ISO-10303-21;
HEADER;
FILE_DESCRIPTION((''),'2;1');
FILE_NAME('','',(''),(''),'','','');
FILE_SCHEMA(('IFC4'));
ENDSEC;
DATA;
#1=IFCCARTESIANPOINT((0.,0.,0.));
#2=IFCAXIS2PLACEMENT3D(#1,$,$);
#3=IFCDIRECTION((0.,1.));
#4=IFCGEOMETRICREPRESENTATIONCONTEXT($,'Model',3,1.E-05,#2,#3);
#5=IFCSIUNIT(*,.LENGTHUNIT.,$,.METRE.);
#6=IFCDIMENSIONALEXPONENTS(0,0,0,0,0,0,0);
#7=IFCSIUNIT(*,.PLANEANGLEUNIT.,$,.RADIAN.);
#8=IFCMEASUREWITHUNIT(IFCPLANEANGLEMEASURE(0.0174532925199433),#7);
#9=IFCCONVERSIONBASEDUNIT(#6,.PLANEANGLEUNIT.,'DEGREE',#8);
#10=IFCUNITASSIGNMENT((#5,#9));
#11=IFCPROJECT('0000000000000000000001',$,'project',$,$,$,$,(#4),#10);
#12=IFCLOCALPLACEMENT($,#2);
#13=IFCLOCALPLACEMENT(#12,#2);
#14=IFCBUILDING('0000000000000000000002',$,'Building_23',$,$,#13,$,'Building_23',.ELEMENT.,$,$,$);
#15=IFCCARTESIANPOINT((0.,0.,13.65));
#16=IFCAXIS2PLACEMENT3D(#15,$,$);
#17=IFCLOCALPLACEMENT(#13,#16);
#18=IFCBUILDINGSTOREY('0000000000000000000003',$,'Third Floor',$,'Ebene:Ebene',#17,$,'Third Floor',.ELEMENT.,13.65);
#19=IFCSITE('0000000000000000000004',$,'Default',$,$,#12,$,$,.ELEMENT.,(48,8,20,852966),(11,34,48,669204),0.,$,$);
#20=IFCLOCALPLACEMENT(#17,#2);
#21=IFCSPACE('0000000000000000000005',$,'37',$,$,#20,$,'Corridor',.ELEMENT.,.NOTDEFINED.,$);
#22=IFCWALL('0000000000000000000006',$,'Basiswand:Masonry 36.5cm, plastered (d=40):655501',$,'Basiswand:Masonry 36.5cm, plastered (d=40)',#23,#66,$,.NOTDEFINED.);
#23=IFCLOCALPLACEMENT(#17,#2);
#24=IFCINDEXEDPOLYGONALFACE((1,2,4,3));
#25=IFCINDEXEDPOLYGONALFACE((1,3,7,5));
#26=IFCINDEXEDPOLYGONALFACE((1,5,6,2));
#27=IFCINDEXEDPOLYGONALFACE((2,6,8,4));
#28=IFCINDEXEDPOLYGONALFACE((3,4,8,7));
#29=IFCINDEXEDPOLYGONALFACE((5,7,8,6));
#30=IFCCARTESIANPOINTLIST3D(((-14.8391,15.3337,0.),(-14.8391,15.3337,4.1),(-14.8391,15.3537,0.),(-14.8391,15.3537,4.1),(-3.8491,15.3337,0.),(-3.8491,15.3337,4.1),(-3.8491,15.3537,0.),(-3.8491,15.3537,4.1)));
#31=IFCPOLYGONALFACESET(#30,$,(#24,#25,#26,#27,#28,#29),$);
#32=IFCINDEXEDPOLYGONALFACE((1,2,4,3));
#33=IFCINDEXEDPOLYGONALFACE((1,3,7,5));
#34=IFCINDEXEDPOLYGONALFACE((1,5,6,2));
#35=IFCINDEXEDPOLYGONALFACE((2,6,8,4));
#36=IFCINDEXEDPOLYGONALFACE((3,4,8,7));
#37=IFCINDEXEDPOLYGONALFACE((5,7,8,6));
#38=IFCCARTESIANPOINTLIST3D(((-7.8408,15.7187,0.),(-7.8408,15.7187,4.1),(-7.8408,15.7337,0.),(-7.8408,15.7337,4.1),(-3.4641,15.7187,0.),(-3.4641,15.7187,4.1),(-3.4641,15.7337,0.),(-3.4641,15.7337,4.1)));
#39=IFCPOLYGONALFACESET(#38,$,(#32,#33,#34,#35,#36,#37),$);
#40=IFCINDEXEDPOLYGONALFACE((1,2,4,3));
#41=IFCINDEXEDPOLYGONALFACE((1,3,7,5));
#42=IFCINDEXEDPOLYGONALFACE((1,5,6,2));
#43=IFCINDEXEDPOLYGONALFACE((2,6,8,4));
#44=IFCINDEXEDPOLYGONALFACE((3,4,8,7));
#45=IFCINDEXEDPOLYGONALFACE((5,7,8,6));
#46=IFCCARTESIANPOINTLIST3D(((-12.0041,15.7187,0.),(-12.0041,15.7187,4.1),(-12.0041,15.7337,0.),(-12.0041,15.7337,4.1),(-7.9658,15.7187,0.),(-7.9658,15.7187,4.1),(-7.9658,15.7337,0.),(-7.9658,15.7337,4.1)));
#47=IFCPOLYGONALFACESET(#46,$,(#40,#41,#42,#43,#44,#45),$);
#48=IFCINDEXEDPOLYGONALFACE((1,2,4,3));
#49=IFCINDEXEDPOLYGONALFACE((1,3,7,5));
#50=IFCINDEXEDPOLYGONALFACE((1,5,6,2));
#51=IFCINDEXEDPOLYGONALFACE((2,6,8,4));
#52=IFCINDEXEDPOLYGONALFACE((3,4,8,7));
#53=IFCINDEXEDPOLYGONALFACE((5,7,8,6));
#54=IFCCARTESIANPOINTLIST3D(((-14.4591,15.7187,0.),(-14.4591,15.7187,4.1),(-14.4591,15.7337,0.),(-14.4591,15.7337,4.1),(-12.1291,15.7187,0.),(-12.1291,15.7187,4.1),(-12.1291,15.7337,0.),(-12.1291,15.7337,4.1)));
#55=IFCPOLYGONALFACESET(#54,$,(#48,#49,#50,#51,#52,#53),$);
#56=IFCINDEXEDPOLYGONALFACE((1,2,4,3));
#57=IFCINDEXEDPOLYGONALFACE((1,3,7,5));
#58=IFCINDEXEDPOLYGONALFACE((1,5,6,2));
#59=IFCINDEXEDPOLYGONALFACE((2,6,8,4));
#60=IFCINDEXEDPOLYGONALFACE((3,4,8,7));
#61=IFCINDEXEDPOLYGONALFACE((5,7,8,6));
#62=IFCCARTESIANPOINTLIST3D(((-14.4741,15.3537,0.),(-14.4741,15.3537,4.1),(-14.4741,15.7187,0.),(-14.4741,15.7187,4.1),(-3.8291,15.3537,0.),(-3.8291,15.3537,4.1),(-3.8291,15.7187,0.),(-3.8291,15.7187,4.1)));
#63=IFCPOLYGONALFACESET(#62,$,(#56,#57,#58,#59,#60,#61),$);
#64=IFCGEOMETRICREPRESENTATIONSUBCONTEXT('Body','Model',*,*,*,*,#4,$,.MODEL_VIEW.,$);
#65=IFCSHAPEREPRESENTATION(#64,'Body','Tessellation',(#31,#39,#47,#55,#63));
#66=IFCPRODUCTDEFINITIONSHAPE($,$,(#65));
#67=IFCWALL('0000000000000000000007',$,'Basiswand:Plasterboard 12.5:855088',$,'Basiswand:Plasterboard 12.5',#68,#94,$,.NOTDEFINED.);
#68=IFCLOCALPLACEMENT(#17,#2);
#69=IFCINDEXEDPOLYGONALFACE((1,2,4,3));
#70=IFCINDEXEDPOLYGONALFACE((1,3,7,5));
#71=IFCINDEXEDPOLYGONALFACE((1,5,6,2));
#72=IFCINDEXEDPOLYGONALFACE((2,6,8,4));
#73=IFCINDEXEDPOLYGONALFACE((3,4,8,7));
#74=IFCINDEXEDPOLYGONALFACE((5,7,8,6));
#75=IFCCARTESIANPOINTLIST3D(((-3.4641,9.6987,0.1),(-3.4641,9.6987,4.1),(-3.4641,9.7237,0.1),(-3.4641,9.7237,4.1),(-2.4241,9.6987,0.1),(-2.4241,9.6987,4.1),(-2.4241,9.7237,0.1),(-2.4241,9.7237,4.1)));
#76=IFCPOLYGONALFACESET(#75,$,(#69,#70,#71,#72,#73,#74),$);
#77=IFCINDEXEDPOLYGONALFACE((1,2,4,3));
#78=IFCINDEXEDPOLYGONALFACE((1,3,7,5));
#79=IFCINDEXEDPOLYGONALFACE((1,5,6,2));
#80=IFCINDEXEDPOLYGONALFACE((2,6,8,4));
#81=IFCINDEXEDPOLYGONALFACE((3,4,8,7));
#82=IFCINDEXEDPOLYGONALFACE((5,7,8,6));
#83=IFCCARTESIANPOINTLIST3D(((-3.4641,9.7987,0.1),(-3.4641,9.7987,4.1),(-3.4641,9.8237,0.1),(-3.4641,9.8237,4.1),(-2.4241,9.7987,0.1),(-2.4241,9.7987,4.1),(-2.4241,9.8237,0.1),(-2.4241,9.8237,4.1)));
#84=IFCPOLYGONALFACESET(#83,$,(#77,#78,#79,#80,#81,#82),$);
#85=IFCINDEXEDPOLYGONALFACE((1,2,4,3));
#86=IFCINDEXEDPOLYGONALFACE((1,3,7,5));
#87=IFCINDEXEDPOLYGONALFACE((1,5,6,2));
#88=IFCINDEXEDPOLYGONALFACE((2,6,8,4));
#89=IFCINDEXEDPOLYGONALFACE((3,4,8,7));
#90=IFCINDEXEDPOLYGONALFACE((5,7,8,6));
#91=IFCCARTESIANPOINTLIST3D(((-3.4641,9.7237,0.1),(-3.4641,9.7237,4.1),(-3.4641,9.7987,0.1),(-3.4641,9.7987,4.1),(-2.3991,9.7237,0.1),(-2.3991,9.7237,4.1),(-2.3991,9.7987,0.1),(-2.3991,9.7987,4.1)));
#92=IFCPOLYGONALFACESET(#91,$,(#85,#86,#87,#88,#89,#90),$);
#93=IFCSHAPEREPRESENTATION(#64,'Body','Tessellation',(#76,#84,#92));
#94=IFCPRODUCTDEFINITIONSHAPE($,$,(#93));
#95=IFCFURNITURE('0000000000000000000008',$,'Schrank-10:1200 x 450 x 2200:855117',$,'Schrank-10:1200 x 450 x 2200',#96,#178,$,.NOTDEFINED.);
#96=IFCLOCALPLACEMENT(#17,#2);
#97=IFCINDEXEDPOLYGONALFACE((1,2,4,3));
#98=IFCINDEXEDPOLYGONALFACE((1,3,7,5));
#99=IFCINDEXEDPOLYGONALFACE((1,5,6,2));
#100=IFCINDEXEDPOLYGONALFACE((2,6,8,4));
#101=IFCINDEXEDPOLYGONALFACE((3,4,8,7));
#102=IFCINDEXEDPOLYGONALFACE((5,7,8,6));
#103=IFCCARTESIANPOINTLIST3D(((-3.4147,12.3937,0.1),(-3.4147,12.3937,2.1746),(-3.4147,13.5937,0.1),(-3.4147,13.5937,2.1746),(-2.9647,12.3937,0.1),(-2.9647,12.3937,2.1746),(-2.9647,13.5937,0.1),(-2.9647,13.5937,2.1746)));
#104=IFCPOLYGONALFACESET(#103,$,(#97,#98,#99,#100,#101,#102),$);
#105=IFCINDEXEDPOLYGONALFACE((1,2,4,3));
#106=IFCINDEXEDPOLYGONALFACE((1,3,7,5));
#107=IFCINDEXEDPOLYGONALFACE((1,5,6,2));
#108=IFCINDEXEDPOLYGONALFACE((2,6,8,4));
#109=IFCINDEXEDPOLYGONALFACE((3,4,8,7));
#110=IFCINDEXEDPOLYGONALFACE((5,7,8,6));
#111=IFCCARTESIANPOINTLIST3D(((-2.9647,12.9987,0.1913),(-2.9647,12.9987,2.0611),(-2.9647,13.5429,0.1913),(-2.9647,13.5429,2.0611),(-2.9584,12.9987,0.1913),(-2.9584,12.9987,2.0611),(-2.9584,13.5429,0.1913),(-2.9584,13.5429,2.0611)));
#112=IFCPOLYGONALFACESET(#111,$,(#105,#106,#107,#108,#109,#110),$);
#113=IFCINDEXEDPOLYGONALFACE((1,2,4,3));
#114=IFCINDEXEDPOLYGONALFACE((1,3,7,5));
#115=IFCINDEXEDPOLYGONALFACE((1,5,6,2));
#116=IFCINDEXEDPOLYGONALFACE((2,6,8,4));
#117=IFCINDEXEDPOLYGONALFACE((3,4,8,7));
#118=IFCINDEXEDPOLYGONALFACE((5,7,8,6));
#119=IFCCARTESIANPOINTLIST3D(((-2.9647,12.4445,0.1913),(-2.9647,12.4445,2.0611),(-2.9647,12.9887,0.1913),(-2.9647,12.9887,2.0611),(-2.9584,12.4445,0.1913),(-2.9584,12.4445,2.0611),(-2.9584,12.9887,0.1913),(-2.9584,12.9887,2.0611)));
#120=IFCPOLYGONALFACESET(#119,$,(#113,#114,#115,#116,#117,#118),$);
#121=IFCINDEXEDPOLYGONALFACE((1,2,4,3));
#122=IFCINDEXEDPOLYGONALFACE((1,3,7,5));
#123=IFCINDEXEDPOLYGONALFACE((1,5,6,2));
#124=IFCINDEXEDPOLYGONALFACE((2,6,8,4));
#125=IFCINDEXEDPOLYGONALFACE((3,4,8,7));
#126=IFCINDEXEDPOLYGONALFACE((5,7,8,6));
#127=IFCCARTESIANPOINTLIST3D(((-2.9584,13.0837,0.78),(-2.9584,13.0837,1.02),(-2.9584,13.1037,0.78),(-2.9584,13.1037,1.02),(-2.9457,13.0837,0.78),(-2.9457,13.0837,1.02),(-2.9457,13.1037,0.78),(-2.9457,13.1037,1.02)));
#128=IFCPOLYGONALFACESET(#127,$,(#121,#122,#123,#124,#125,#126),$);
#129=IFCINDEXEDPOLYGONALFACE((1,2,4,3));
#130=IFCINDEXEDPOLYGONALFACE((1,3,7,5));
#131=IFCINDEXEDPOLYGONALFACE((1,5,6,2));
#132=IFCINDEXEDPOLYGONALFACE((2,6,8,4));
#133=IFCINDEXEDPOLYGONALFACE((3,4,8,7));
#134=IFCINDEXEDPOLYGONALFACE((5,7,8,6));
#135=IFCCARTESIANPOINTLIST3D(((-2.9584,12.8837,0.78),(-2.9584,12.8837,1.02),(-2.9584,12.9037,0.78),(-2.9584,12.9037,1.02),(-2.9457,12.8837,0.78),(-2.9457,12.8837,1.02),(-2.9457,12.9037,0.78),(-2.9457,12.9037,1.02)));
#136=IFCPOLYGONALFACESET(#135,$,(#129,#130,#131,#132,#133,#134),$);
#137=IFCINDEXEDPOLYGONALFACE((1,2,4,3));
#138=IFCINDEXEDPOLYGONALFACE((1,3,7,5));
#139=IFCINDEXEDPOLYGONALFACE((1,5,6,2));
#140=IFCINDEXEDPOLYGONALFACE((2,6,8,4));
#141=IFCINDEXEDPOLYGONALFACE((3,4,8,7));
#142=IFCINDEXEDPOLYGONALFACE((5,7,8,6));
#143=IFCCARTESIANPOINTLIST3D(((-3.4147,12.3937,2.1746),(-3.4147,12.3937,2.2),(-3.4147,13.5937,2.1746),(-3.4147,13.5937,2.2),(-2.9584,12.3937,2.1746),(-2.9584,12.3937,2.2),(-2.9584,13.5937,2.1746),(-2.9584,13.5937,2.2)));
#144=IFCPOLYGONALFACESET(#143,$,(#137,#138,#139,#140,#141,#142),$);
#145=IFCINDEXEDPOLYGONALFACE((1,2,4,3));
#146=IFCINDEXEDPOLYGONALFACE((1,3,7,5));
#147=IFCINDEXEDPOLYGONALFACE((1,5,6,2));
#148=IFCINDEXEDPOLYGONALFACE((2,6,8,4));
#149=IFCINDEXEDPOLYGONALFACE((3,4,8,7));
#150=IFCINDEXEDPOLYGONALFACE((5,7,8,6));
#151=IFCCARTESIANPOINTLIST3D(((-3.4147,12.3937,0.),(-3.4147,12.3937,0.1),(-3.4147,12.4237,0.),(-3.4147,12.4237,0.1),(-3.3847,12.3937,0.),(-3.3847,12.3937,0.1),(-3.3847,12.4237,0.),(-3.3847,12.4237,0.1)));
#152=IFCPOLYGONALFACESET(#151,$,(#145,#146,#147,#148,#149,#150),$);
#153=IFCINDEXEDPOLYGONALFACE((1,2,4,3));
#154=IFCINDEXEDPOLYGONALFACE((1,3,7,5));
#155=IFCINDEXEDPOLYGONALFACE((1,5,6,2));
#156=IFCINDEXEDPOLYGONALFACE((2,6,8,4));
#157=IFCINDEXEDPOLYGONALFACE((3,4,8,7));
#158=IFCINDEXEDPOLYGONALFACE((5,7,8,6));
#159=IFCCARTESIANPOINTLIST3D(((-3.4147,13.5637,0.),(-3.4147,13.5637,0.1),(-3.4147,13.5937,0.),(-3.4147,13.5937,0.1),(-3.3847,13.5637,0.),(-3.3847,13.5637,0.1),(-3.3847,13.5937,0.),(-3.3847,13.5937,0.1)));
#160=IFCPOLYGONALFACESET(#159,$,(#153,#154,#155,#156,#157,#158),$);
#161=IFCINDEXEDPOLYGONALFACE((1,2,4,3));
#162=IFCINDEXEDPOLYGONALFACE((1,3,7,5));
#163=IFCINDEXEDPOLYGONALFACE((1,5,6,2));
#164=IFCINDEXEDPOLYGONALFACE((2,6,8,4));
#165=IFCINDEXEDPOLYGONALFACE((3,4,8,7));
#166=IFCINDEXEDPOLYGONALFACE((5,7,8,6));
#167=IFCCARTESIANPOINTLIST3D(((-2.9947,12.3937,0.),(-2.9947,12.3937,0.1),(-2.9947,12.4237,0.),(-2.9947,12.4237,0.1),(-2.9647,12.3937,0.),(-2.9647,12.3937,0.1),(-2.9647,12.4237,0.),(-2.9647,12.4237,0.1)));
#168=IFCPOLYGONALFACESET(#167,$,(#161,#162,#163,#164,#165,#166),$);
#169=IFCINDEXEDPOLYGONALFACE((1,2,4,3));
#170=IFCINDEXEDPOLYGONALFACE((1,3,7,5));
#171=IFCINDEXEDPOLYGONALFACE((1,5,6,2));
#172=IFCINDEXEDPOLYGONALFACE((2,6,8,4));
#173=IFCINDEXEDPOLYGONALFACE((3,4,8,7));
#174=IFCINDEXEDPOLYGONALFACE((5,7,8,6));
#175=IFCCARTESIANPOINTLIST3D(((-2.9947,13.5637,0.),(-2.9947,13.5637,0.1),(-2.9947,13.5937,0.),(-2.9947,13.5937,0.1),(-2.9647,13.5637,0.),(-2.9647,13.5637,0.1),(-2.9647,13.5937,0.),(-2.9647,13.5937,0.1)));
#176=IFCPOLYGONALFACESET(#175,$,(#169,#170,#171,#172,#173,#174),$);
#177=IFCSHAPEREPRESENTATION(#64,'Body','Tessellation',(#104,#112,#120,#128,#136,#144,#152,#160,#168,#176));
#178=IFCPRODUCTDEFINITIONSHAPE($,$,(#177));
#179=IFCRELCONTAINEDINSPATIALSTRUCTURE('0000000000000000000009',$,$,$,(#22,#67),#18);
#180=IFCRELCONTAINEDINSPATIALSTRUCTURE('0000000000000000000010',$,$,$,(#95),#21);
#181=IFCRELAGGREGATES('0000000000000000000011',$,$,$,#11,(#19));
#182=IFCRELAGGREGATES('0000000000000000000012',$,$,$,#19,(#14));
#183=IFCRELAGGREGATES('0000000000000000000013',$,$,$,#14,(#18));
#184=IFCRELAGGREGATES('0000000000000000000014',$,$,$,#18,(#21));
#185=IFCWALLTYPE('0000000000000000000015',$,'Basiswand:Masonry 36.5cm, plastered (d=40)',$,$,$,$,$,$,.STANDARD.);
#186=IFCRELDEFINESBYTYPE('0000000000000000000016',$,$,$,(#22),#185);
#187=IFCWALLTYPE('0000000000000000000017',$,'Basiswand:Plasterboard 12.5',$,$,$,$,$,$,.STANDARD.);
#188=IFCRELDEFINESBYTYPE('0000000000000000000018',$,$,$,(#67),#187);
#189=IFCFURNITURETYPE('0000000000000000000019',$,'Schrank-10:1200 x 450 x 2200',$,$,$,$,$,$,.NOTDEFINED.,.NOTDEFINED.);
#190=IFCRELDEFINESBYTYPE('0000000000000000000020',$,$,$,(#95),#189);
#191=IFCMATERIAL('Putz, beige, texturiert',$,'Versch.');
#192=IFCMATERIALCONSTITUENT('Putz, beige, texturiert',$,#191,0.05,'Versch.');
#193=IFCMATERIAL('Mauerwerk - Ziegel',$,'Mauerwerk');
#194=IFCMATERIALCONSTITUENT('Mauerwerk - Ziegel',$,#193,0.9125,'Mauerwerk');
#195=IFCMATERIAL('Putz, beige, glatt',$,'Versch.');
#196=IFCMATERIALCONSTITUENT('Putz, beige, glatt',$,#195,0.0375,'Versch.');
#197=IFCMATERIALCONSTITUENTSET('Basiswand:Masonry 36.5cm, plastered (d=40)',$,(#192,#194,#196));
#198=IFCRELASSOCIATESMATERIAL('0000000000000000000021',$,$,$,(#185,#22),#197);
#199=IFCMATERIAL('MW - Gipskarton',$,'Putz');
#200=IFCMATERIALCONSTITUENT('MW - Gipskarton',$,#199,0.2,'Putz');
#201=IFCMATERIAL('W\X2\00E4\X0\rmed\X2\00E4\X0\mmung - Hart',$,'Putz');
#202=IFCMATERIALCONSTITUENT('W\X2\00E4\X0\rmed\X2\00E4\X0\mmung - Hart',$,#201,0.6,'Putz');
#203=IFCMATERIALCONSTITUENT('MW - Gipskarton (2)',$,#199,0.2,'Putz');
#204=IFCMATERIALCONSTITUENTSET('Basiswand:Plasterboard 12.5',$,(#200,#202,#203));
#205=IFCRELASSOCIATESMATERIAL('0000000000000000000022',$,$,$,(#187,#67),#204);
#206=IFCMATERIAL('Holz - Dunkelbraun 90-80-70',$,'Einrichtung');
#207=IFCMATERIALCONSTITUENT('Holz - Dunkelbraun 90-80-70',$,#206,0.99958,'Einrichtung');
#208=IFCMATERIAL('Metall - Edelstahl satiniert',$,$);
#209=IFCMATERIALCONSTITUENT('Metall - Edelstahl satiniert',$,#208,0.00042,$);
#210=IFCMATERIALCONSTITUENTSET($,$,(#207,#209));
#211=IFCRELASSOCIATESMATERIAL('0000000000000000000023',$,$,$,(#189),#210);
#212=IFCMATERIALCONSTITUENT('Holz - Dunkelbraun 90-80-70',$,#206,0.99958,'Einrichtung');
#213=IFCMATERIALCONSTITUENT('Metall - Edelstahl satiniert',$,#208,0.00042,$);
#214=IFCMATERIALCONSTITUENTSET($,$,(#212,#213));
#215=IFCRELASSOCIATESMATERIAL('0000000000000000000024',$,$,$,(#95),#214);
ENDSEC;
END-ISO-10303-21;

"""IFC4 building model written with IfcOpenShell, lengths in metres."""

from ifc_helpers import new_model, entity, si_unit, converted_unit, direction, frame, origin, place, context, subcontext, project, spatial, indexed_curve, outline, extrude, source, transform, mapped, material, constituent, constituent_set, type_object, type_shapes, element, save


model = new_model("IFC4")

# Units and contexts
model_context = context("Model", 3, precision=1e-05, world=origin(), true_north=direction((0.0, 1.0)))
body_context = subcontext(model_context, "Body", "Model", "MODEL_VIEW")
ifc_project = project(units=[si_unit("LENGTHUNIT", "METRE"), converted_unit("PLANEANGLEUNIT", "DEGREE", entity("IfcPlaneAngleMeasure", 0.0174532925199433), si_unit("PLANEANGLEUNIT", "RADIAN"), dimensions=[0, 0, 0, 0, 0, 0, 0])], contexts=[model_context])

# Site, building, storey
site_placement = place(None, origin())
site = spatial("IfcSite", under=ifc_project, at=site_placement, Name="Default", CompositionType="ELEMENT", RefLatitude=(48, 8, 20, 852966), RefLongitude=(11, 34, 48, 669204), RefElevation=0.0)
building_placement = place(site_placement, origin())
building = spatial("IfcBuilding", under=site, at=building_placement, Name="Building_23", LongName="Building_23", CompositionType="ELEMENT")
storey_placement = place(building_placement, frame((0.0, 0.0, 13.65)))
storey = spatial("IfcBuildingStorey", under=building, at=storey_placement, Name="Third Floor", ObjectType="Ebene:Ebene", LongName="Third Floor", CompositionType="ELEMENT", Elevation=13.65)

# Shared definitions
ifc_material_1 = material(Name="Putz, beige, texturiert", Category="Versch.")
ifc_constituent_1 = constituent(ifc_material_1, Name="Putz, beige, texturiert", Category="Versch.", fraction=0.05)
ifc_material_2 = material(Name="Mauerwerk - Ziegel", Category="Mauerwerk")
ifc_constituent_2 = constituent(ifc_material_2, Name="Mauerwerk - Ziegel", Category="Mauerwerk", fraction=0.9125)
ifc_material_3 = material(Name="Putz, beige, glatt", Category="Versch.")
ifc_constituent_3 = constituent(ifc_material_3, Name="Putz, beige, glatt", Category="Versch.", fraction=0.0375)
ifc_constituent_set_1 = constituent_set(constituents=[ifc_constituent_1, ifc_constituent_2, ifc_constituent_3], Name="Basiswand:Masonry 36.5cm, plastered (d=40)")
wall_type_1 = type_object("IfcWallType", Name="Basiswand:Masonry 36.5cm, plastered (d=40)", PredefinedType="STANDARD", material=ifc_constituent_set_1)

# Wall
wall_1_placement = place(storey_placement, frame((-14.4591, 15.5337, 0.0)))
element("IfcWall", 1, at=wall_1_placement, inside=storey, type_object=wall_type_1, material=ifc_constituent_set_1, Name="Basiswand:Masonry 36.5cm, plastered (d=40):655501", ObjectType="Basiswand:Masonry 36.5cm, plastered (d=40)", PredefinedType="NOTDEFINED", context=body_context, shape_type="SweptSolid", body=[
    extrude(outline(indexed_curve([(-0.01, -5.495), (0.01, -5.495), (0.01, 5.495), (-0.01, 5.495), (-0.01, -5.495)], self_intersect=False)), frame((5.115, -0.19, 0.0), z_axis=(0.0, 0.0, 1.0), x_axis=(0.0, 1.0, 0.0)), (0.0, 0.0, 1.0), 4.1),
    extrude(outline(indexed_curve([(-2.1884, -0.0075), (2.1884, -0.0075), (2.1884, 0.0075), (-2.1884, 0.0075), (-2.1884, -0.0075)], self_intersect=False)), frame((8.8066, 0.1925, 0.0), z_axis=(0.0, 0.0, 1.0), x_axis=(-1.0, 0.0, 0.0)), (0.0, 0.0, 1.0), 4.1),
    extrude(outline(indexed_curve([(-2.0191, -0.0075), (2.0191, -0.0075), (2.0191, 0.0075), (-2.0191, 0.0075), (-2.0191, -0.0075)], self_intersect=False)), frame((4.4741, 0.1925, 0.0), z_axis=(0.0, 0.0, 1.0), x_axis=(-1.0, 0.0, 0.0)), (0.0, 0.0, 1.0), 4.1),
    extrude(outline(indexed_curve([(-1.165, -0.0075), (1.165, -0.0075), (1.165, 0.0075), (-1.165, 0.0075), (-1.165, -0.0075)], self_intersect=False)), frame((1.165, 0.1925, 0.0)), (0.0, 0.0, 1.0), 4.1),
    extrude(outline(indexed_curve([(-5.3225, -0.1825), (5.3225, -0.1825), (5.3225, 0.1825), (-5.3225, 0.1825), (-5.3225, -0.1825)], self_intersect=False)), frame((5.3075, 0.0025, 0.0)), (0.0, 0.0, 1.0), 4.1),
])

# Shared definitions
ifc_material_4 = material(Name="MW - Gipskarton", Category="Putz")
ifc_constituent_4 = constituent(ifc_material_4, Name="MW - Gipskarton", Category="Putz", fraction=0.2)
ifc_material_5 = material(Name="Wärmedämmung - Hart", Category="Putz")
ifc_constituent_5 = constituent(ifc_material_5, Name="Wärmedämmung - Hart", Category="Putz", fraction=0.6)
ifc_constituent_6 = constituent(ifc_material_4, Name="MW - Gipskarton (2)", Category="Putz", fraction=0.2)
ifc_constituent_set_2 = constituent_set(constituents=[ifc_constituent_4, ifc_constituent_5, ifc_constituent_6], Name="Basiswand:Plasterboard 12.5")
wall_type_2 = type_object("IfcWallType", Name="Basiswand:Plasterboard 12.5", PredefinedType="STANDARD", material=ifc_constituent_set_2)

# Wall
wall_2_placement = place(storey_placement, frame((-3.4491, 9.7612, 0.1)))
element("IfcWall", 2, at=wall_2_placement, inside=storey, type_object=wall_type_2, material=ifc_constituent_set_2, Name="Basiswand:Plasterboard 12.5:855088", ObjectType="Basiswand:Plasterboard 12.5", PredefinedType="NOTDEFINED", context=body_context, shape_type="SweptSolid", body=[
    extrude(outline(indexed_curve([(-0.0125, -0.52), (0.0125, -0.52), (0.0125, 0.52), (-0.0125, 0.52), (-0.0125, -0.52)], self_intersect=False)), frame((0.505, -0.05, 0.0), z_axis=(0.0, 0.0, 1.0), x_axis=(0.0, 1.0, 0.0)), (0.0, 0.0, 1.0), 4.0),
    extrude(outline(indexed_curve([(-0.0125, -0.52), (0.0125, -0.52), (0.0125, 0.52), (-0.0125, 0.52), (-0.0125, -0.52)], self_intersect=False)), frame((0.505, 0.05, 0.0), z_axis=(0.0, 0.0, 1.0), x_axis=(0.0, -1.0, 0.0)), (0.0, 0.0, 1.0), 4.0),
    extrude(outline(indexed_curve([(-0.5325, -0.0375), (0.5325, -0.0375), (0.5325, 0.0375), (-0.5325, 0.0375), (-0.5325, -0.0375)], self_intersect=False)), frame((0.5175, 0.0, 0.0), z_axis=(0.0, 0.0, 1.0), x_axis=(-1.0, 0.0, 0.0)), (0.0, 0.0, 1.0), 4.0),
])

# Shared definitions
ifc_material_6 = material(Name="Metall - Edelstahl satiniert")
ifc_material_7 = material(Name="Holz - Dunkelbraun 90-80-70", Category="Einrichtung")

# Shared definitions
space_1_placement = place(storey_placement, origin())
space_1 = spatial("IfcSpace", under=storey, at=space_1_placement, Name="37", LongName="Corridor", CompositionType="ELEMENT", PredefinedType="NOTDEFINED")

# Furniture
ifc_constituent_7 = constituent(ifc_material_7, Name="Holz - Dunkelbraun 90-80-70", Category="Einrichtung", fraction=0.99958)
ifc_constituent_8 = constituent(ifc_material_6, Name="Metall - Edelstahl satiniert", fraction=0.00042)
ifc_constituent_set_3 = constituent_set(constituents=[ifc_constituent_7, ifc_constituent_8])
ifc_constituent_9 = constituent(ifc_material_7, Name="Holz - Dunkelbraun 90-80-70", Category="Einrichtung", fraction=0.99958)
ifc_constituent_10 = constituent(ifc_material_6, Name="Metall - Edelstahl satiniert", fraction=0.00042)
ifc_constituent_set_4 = constituent_set(constituents=[ifc_constituent_9, ifc_constituent_10])
furniture_type_1 = type_object("IfcFurnitureType", Name="Schrank-10:1200 x 450 x 2200", AssemblyPlace="NOTDEFINED", PredefinedType="NOTDEFINED", material=ifc_constituent_set_4)
shared_shape_1 = source(origin(), body_context, "Body", "SweptSolid", [
    extrude(outline(indexed_curve([(-0.225, -0.6), (0.225, -0.6), (0.225, 0.6), (-0.225, 0.6), (-0.225, -0.6)], self_intersect=False)), frame((-0.2692, -0.3632, 0.1), z_axis=(0.0, 0.0, 1.0), x_axis=(0.0, 1.0, 0.0)), (0.0, 0.0, 1.0), 2.0746),
    extrude(outline(indexed_curve([(-0.0032, -0.2721), (0.0032, -0.2721), (0.0032, 0.2721), (-0.0032, 0.2721), (-0.0032, -0.2721)], self_intersect=False)), frame((0.0079, -0.5913, 0.1913), z_axis=(0.0, 0.0, 1.0), x_axis=(0.0, 1.0, 0.0)), (0.0, 0.0, 1.0), 1.8698),
    extrude(outline(indexed_curve([(-0.0032, -0.2721), (0.0032, -0.2721), (0.0032, 0.2721), (-0.0032, 0.2721), (-0.0032, -0.2721)], self_intersect=False)), frame((-0.5463, -0.5913, 0.1913), z_axis=(0.0, 0.0, 1.0), x_axis=(0.0, 1.0, 0.0)), (0.0, 0.0, 1.0), 1.8698),
    extrude(outline(indexed_curve([(-0.0063, -0.01), (0.0063, -0.01), (0.0063, 0.01), (-0.0063, 0.01), (-0.0063, -0.01)], self_intersect=False)), frame((-0.1692, -0.6009, 0.78), z_axis=(0.0, 0.0, 1.0), x_axis=(0.0, 1.0, 0.0)), (0.0, 0.0, 1.0), 0.24),
    extrude(outline(indexed_curve([(-0.0063, -0.01), (0.0063, -0.01), (0.0063, 0.01), (-0.0063, 0.01), (-0.0063, -0.01)], self_intersect=False)), frame((-0.3692, -0.6009, 0.78), z_axis=(0.0, 0.0, 1.0), x_axis=(0.0, 1.0, 0.0)), (0.0, 0.0, 1.0), 0.24),
    extrude(outline(indexed_curve([(-0.6, -0.2282), (0.6, -0.2282), (0.6, 0.2282), (-0.6, 0.2282), (-0.6, -0.2282)], self_intersect=False)), frame((-0.2692, -0.3663, 2.1746), z_axis=(0.0, 0.0, 1.0), x_axis=(-1.0, 0.0, 0.0)), (0.0, 0.0, 1.0), 0.0254),
    extrude(outline(indexed_curve([(-0.015, -0.015), (0.015, -0.015), (0.015, 0.015), (-0.015, 0.015), (-0.015, -0.015)], self_intersect=False)), frame((-0.8542, -0.1532, 0.0), z_axis=(0.0, 0.0, 1.0), x_axis=(-1.0, 0.0, 0.0)), (0.0, 0.0, 1.0), 0.1),
    extrude(outline(indexed_curve([(-0.015, -0.015), (0.015, -0.015), (0.015, 0.015), (-0.015, 0.015), (-0.015, -0.015)], self_intersect=False)), frame((0.3158, -0.1532, 0.0), z_axis=(0.0, 0.0, 1.0), x_axis=(0.0, -1.0, 0.0)), (0.0, 0.0, 1.0), 0.1),
    extrude(outline(indexed_curve([(-0.015, -0.015), (0.015, -0.015), (0.015, 0.015), (-0.015, 0.015), (-0.015, -0.015)], self_intersect=False)), frame((-0.8542, -0.5732, 0.0), z_axis=(0.0, 0.0, 1.0), x_axis=(0.0, 1.0, 0.0)), (0.0, 0.0, 1.0), 0.1),
    extrude(outline(indexed_curve([(-0.015, -0.015), (0.015, -0.015), (0.015, 0.015), (-0.015, 0.015), (-0.015, -0.015)], self_intersect=False)), frame((0.3158, -0.5732, 0.0)), (0.0, 0.0, 1.0), 0.1),
])
type_shapes(furniture_type_1, [shared_shape_1])
furniture_1_placement = place(space_1_placement, frame((-3.5529, 13.2629, 0.0), z_axis=(0.0, 0.0, 1.0), x_axis=(0.0, 1.0, 0.0)))
element("IfcFurniture", 3, at=furniture_1_placement, inside=space_1, type_object=furniture_type_1, material=ifc_constituent_set_3, Name="Schrank-10:1200 x 450 x 2200:855117", ObjectType="Schrank-10:1200 x 450 x 2200", PredefinedType="NOTDEFINED", context=body_context, shape_type="MappedRepresentation", body=[
    mapped(shared_shape_1, transform((0.0, 0.0, 0.0), scale=1.0)),
])

save(model, "model.ifc")
